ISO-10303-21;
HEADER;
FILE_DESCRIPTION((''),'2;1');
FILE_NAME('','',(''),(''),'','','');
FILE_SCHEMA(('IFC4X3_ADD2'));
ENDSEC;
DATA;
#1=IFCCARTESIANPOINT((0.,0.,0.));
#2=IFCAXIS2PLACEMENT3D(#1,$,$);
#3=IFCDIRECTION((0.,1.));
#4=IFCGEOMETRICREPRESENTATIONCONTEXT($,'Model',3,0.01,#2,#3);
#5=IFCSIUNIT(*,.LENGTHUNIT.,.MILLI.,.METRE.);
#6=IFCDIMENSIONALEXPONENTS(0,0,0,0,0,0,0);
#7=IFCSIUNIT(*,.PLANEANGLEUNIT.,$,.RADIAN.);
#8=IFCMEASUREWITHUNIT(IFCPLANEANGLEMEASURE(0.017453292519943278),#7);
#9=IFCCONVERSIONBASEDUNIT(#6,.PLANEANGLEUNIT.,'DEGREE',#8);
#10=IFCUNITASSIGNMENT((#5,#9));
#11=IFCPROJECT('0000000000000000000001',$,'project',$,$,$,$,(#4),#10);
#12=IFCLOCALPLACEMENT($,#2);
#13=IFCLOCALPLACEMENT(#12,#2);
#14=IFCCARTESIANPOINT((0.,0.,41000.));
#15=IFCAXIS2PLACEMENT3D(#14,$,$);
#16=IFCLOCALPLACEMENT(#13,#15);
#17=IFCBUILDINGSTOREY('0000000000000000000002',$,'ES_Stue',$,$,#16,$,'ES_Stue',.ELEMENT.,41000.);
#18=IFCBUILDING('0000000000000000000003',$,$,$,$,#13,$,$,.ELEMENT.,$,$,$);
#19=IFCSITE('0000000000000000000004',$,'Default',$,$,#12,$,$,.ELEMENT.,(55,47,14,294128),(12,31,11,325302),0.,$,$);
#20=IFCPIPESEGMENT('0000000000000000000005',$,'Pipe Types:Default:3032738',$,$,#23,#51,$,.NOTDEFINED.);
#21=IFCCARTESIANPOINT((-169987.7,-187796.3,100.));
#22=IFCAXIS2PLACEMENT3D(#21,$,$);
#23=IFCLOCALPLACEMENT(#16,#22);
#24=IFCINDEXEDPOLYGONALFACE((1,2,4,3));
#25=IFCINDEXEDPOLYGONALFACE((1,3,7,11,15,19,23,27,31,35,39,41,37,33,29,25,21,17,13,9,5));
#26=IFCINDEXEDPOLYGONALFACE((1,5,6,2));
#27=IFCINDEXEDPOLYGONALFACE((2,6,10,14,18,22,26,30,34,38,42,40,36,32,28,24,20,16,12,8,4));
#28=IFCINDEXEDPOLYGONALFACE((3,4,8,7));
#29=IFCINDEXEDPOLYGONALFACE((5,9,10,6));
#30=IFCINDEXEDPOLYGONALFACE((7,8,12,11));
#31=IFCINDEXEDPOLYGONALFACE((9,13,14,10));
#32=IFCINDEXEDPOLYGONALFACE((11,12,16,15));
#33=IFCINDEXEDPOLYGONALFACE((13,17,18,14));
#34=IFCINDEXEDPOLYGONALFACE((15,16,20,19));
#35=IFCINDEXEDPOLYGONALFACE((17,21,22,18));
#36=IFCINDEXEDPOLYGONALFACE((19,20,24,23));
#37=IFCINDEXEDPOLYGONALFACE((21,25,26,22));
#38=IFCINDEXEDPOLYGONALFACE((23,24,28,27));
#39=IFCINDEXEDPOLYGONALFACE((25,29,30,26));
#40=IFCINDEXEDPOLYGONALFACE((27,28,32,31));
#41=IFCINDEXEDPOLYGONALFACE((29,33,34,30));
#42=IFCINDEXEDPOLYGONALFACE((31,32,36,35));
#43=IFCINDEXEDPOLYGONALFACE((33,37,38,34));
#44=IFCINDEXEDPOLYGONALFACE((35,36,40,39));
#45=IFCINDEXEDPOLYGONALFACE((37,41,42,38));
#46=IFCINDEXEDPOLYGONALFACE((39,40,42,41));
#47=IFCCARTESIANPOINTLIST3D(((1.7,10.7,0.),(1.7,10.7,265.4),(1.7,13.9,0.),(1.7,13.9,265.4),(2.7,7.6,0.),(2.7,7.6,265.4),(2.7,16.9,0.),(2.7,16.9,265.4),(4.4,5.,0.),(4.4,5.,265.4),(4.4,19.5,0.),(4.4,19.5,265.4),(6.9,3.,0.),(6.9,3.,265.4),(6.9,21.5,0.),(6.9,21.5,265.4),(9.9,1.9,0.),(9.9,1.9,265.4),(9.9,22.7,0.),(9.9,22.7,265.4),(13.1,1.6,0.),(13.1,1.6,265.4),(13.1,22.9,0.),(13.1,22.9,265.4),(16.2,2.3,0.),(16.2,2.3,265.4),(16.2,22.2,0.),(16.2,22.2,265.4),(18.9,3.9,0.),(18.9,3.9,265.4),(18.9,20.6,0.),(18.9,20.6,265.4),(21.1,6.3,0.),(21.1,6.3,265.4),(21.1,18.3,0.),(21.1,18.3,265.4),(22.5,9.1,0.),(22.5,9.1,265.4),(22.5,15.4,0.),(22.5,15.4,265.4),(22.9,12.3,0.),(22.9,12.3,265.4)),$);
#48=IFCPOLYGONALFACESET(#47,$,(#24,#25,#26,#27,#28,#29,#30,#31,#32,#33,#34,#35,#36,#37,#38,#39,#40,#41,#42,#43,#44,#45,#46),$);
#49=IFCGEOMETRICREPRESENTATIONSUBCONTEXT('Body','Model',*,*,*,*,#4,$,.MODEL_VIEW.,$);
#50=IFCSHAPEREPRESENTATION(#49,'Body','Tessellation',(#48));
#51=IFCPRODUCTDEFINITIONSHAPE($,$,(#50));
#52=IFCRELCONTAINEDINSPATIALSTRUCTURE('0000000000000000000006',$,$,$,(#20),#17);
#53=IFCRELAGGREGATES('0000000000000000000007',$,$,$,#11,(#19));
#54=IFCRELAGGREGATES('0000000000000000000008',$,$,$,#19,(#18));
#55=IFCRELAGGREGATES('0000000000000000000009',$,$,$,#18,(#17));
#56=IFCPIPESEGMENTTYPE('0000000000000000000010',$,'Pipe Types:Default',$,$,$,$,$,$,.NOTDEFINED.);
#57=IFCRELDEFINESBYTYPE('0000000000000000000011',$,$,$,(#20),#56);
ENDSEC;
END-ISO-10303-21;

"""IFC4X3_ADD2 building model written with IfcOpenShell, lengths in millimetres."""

from ifc_helpers import new_model, entity, si_unit, converted_unit, direction, frame, origin, origin_2d_with_axis, place, context, subcontext, project, spatial, circle, extrude, type_object, element, save


model = new_model("IFC4X3_ADD2")

# Units and contexts
model_context = context("Model", 3, precision=0.01, world=origin(), true_north=direction((0.0, 1.0)))
body_context = subcontext(model_context, "Body", "Model", "MODEL_VIEW")
ifc_project = project(units=[si_unit("LENGTHUNIT", "METRE", prefix="MILLI"), converted_unit("PLANEANGLEUNIT", "DEGREE", entity("IfcPlaneAngleMeasure", 0.017453292519943278), si_unit("PLANEANGLEUNIT", "RADIAN"), dimensions=[0, 0, 0, 0, 0, 0, 0])], contexts=[model_context])

# Site, building, storey
site_placement = place(None, origin())
site = spatial("IfcSite", under=ifc_project, at=site_placement, Name="Default", CompositionType="ELEMENT", RefLatitude=(55, 47, 14, 294128), RefLongitude=(12, 31, 11, 325302), RefElevation=0.0)
building_placement = place(site_placement, origin())
building = spatial("IfcBuilding", under=site, at=building_placement, CompositionType="ELEMENT")
storey_placement = place(building_placement, frame((0.0, 0.0, 41000.0)))
storey = spatial("IfcBuildingStorey", under=building, at=storey_placement, Name="ES_Stue", LongName="ES_Stue", CompositionType="ELEMENT", Elevation=41000.0)

# Pipe segment
pipe_segment_type = type_object("IfcPipeSegmentType", Name="Pipe Types:Default", PredefinedType="NOTDEFINED")
for number, where, name in (
    (1, (-169987.7, -187796.3, 100.0), "Pipe Types:Default:3032738"),
):
    element("IfcPipeSegment", number, at=place(storey_placement, frame(where)), inside=storey, type_object=pipe_segment_type, Name=name, PredefinedType="NOTDEFINED", context=body_context, shape_type="SweptSolid", body=[
        extrude(circle(Radius=10.7, at=origin_2d_with_axis()), frame((12.3, 12.3, 0.0)), (0.0, 0.0, 1.0), 265.4),
    ])

save(model, "model.ifc")
